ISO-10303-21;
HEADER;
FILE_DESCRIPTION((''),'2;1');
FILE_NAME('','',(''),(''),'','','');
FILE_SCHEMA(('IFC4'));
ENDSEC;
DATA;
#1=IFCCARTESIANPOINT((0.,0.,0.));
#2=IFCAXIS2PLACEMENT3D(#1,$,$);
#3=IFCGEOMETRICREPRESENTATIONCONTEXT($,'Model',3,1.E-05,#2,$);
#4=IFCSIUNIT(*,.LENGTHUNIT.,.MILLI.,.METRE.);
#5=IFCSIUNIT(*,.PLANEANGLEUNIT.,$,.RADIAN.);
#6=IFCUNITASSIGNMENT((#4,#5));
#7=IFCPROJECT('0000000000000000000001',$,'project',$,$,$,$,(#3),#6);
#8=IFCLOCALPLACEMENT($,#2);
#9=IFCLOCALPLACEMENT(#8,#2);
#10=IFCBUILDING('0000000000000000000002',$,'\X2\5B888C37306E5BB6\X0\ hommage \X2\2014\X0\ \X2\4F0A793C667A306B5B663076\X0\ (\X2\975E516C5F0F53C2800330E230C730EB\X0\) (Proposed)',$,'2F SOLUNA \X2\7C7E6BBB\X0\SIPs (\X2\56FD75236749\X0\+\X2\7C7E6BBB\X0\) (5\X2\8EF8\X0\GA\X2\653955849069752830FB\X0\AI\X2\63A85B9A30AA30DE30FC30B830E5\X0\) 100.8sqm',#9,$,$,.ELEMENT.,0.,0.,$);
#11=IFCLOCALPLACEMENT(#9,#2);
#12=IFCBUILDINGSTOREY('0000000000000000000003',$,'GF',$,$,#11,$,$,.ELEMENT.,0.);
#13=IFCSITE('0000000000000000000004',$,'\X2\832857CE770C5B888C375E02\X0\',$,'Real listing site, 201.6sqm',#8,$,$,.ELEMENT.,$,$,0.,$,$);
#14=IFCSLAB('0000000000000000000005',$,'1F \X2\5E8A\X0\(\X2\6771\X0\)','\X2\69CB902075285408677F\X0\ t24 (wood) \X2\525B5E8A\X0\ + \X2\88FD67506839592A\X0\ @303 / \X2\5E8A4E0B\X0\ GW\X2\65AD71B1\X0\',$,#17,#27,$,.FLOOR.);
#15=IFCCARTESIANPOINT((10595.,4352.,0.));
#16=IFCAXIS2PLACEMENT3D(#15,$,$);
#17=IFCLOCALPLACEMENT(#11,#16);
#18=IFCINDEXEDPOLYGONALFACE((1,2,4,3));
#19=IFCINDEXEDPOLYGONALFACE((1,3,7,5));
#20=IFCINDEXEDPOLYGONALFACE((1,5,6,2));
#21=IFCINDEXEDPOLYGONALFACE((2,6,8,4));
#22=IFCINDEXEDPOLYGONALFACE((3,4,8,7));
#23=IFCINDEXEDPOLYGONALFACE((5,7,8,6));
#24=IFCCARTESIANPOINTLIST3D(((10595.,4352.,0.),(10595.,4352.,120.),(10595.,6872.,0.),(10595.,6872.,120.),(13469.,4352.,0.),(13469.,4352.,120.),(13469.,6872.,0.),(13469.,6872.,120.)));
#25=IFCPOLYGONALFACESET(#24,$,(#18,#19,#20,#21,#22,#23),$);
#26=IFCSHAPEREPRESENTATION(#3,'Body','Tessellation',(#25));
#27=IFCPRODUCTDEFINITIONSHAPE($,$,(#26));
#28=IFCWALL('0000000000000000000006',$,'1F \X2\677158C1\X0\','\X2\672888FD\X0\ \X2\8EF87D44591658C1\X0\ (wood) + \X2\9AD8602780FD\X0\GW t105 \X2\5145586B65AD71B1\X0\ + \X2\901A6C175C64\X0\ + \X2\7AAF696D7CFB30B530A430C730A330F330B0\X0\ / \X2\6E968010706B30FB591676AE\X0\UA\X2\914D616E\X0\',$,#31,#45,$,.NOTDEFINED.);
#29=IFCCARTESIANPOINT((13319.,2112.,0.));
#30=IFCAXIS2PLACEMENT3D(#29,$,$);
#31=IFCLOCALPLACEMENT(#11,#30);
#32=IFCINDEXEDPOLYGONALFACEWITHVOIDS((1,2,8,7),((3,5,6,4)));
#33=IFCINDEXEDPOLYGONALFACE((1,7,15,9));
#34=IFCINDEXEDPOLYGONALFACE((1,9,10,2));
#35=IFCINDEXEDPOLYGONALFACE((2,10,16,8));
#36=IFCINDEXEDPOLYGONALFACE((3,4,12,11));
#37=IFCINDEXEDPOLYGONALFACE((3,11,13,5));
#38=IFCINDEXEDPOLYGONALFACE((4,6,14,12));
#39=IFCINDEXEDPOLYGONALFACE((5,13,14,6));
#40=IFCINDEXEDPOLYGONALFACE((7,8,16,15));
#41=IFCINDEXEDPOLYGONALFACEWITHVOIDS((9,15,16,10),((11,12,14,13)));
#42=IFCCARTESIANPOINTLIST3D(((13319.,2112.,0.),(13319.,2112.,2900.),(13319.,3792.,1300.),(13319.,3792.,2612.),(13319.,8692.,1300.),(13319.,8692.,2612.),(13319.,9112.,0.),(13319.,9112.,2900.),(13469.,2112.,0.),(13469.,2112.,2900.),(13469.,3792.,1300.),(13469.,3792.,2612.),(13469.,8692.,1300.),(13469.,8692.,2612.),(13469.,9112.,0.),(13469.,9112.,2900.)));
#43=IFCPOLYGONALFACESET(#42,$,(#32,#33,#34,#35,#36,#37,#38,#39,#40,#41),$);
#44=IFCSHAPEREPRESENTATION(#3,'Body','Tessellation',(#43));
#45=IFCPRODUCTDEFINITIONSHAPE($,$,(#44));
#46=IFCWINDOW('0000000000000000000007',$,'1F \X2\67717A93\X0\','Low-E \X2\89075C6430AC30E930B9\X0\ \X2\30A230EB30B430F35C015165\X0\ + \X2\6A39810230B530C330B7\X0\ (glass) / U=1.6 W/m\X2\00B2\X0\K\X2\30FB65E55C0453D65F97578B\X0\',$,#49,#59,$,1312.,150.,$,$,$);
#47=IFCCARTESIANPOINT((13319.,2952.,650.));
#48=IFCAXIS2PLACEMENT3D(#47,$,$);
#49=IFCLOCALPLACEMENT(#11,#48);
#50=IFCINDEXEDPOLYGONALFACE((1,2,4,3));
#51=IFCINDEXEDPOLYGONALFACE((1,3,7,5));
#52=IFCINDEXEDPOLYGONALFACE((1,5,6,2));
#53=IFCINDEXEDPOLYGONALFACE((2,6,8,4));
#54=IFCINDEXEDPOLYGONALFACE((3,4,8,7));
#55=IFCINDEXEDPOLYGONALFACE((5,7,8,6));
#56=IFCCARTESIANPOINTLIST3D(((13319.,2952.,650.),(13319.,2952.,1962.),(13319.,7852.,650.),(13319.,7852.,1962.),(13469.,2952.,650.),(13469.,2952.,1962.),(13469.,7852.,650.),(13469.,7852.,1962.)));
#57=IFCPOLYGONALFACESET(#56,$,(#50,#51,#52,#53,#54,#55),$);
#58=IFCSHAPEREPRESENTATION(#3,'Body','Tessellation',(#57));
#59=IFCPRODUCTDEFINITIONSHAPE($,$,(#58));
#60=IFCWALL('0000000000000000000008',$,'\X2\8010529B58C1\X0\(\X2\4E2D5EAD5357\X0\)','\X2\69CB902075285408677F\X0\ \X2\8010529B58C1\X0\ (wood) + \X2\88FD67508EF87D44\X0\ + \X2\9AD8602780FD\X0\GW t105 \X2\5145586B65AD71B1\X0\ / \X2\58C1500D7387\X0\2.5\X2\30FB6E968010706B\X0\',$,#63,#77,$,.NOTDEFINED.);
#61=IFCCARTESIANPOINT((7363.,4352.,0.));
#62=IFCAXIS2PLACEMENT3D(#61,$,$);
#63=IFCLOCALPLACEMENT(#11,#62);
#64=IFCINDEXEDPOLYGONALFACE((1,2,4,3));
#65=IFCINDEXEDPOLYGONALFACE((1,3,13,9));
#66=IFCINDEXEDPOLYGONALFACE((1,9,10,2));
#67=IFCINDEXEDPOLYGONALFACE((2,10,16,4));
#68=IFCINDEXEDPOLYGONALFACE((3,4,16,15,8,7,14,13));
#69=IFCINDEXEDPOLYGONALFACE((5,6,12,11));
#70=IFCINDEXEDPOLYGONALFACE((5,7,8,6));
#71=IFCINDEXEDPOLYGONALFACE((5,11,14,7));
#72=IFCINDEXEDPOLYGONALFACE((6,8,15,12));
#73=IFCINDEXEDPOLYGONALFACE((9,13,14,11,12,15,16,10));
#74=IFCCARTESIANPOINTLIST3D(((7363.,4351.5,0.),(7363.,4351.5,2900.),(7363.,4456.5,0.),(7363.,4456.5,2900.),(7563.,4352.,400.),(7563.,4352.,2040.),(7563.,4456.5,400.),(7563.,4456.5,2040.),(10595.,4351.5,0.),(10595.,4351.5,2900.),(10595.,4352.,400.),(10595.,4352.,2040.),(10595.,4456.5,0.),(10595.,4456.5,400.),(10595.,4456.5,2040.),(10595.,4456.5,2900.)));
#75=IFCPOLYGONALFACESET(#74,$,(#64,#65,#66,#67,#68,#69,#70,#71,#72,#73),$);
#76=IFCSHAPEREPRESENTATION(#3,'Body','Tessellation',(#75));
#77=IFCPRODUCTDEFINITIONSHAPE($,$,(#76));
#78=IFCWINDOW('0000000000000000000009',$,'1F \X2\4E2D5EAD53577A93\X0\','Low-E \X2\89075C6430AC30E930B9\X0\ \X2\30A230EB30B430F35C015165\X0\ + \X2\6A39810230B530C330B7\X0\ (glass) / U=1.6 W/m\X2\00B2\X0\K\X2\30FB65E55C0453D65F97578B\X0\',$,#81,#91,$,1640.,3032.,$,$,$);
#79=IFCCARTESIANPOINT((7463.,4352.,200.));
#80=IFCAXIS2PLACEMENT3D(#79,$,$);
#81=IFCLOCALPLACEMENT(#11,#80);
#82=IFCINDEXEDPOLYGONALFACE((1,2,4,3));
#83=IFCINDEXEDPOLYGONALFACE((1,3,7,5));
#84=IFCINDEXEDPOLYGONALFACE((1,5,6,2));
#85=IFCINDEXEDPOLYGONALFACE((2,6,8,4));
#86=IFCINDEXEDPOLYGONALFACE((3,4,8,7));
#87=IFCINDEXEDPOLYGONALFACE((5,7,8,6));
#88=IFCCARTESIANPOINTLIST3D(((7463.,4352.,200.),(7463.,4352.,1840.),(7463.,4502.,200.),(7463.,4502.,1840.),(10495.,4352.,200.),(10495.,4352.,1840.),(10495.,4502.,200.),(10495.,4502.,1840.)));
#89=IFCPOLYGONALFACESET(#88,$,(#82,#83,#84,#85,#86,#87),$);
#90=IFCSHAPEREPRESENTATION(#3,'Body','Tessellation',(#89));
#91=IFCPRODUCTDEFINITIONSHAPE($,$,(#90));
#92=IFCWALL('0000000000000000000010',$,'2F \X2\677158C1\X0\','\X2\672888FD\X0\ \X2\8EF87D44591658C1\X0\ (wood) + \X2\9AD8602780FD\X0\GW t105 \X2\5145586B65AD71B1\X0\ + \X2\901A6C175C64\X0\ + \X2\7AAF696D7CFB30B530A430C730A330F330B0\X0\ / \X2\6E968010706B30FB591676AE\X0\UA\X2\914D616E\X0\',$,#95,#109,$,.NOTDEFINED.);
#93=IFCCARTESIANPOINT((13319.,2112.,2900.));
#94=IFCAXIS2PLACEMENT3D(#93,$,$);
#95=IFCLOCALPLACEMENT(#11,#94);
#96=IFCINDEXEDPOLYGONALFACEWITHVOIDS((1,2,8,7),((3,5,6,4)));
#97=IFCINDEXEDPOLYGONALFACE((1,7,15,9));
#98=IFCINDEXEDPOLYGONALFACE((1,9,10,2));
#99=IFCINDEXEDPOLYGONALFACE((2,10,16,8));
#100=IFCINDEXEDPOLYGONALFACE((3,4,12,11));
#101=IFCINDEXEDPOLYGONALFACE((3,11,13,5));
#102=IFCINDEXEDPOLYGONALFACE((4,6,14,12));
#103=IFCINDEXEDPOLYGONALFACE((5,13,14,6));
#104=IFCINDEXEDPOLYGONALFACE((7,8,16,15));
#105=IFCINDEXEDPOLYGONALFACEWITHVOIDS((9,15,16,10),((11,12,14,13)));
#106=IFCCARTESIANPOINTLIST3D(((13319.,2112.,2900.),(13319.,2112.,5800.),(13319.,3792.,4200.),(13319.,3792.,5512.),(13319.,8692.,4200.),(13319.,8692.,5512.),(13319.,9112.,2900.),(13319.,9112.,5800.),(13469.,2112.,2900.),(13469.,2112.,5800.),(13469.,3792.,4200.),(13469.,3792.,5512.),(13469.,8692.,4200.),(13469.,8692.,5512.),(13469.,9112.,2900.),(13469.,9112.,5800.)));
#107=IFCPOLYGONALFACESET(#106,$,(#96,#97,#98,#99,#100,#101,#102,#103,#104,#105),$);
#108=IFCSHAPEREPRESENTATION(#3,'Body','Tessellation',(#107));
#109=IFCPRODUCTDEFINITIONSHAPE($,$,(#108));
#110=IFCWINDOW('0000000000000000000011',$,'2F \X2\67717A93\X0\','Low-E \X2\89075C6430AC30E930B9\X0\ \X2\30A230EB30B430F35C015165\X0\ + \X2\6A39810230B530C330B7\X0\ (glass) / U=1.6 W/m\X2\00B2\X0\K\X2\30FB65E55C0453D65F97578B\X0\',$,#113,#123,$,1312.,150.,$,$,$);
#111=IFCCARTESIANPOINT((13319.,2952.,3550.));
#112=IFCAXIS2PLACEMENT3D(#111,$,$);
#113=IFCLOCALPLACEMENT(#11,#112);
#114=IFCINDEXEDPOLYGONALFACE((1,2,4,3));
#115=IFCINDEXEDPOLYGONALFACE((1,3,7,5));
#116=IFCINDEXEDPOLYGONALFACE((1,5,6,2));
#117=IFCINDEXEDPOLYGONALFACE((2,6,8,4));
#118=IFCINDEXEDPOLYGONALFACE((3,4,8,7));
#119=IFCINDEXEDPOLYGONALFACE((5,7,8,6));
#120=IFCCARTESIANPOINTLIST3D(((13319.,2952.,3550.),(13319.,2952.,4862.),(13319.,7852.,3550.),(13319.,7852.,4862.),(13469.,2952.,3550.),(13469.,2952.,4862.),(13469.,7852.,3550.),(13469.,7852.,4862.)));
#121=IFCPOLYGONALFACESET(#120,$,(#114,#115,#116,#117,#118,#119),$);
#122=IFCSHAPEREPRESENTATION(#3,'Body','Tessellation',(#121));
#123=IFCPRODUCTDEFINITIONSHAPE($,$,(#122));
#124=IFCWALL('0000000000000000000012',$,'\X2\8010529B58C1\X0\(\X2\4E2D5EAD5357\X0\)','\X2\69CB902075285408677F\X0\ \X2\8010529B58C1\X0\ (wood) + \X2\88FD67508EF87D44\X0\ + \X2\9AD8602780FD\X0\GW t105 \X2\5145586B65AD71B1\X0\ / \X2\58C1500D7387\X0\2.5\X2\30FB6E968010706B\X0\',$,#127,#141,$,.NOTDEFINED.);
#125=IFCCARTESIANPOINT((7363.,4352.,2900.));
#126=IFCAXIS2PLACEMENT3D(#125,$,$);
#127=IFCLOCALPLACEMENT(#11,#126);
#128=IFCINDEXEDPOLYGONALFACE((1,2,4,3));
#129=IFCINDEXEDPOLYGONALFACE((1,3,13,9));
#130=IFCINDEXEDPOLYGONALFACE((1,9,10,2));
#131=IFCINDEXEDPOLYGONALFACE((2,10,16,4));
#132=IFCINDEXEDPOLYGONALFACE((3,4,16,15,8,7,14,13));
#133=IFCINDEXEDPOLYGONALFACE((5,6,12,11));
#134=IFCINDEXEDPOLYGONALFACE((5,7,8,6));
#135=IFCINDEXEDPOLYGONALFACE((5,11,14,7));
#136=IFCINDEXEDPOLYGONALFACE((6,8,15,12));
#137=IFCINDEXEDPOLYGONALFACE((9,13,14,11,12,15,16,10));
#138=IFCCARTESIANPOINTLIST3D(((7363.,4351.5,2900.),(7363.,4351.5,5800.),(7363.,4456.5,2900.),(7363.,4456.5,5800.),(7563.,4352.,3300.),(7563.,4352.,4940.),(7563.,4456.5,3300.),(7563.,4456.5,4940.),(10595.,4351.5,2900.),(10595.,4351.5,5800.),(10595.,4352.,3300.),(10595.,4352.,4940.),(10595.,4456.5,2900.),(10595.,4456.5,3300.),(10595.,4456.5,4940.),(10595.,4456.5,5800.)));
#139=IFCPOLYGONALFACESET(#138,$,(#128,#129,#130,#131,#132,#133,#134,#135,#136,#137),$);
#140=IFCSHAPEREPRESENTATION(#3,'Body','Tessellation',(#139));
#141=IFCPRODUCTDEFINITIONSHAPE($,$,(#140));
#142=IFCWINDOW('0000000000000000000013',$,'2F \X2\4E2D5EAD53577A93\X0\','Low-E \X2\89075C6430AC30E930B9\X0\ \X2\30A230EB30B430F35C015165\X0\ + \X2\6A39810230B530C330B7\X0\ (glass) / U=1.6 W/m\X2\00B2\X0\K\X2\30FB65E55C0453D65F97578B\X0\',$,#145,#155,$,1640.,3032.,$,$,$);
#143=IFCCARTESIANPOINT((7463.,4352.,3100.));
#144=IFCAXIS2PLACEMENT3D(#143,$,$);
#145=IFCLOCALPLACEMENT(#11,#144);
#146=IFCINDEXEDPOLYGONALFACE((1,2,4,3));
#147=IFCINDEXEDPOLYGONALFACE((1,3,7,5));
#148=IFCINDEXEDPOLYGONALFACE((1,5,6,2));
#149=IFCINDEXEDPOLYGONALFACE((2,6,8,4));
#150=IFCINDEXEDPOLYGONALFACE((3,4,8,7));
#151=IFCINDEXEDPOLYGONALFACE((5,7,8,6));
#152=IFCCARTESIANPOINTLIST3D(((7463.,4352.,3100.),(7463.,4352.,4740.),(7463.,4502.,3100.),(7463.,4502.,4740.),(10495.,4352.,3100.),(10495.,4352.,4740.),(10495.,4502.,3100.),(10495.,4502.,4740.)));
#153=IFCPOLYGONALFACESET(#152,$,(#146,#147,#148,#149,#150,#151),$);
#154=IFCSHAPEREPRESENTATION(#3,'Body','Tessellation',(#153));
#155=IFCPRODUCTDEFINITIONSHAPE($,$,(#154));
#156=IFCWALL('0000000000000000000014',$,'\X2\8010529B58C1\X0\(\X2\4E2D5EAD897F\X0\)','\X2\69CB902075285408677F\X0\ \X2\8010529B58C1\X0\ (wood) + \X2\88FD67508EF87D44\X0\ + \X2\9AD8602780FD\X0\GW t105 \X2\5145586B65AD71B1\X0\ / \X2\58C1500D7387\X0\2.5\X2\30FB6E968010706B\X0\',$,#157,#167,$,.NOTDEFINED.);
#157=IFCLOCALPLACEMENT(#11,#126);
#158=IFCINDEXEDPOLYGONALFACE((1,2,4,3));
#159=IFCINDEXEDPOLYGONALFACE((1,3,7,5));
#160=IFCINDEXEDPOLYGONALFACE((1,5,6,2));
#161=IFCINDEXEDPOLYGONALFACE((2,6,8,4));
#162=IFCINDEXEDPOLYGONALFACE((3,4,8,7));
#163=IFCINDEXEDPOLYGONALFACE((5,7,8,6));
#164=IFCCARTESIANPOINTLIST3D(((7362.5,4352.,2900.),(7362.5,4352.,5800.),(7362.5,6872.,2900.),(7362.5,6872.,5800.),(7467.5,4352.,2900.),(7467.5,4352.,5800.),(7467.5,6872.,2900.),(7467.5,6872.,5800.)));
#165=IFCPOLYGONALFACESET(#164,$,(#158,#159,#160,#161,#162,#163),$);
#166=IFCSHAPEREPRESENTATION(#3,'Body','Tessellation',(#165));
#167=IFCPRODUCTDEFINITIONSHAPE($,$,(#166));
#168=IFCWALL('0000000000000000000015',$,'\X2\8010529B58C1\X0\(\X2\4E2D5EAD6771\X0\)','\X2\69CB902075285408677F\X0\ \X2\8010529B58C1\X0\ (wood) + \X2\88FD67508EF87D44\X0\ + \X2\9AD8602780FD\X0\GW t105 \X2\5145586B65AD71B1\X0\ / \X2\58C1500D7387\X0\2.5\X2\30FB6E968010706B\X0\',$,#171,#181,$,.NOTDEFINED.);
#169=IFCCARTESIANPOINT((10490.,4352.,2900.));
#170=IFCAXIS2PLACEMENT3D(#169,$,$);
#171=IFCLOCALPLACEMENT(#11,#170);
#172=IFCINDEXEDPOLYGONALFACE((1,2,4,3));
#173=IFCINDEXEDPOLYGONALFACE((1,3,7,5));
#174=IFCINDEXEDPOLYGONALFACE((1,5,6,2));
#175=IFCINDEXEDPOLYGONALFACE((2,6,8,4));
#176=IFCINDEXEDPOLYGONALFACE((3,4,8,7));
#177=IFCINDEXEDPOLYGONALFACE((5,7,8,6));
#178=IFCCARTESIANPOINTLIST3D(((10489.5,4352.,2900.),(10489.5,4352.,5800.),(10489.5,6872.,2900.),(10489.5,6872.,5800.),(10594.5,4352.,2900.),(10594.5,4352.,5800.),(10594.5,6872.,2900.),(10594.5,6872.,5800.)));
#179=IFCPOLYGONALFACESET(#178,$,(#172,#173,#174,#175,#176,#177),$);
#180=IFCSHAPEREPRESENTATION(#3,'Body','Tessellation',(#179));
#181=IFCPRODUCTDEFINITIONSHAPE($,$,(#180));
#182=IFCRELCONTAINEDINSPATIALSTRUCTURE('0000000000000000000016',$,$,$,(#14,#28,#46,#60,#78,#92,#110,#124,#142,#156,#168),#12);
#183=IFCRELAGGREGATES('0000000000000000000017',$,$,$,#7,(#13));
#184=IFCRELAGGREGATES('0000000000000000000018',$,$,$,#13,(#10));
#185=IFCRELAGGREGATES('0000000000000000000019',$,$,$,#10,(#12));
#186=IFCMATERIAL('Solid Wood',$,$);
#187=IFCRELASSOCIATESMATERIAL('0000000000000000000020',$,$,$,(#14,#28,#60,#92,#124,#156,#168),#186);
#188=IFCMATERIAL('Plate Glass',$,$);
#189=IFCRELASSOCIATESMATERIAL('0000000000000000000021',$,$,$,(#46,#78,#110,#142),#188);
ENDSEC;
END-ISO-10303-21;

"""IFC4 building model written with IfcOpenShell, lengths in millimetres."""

from ifc_helpers import new_model, si_unit, frame, frame_2d, origin, place, context, project, spatial, rectangle, extrude, material, element, fill, save


model = new_model("IFC4")

# Units and contexts
model_context = context("Model", 3, precision=1e-05, world=origin())
ifc_project = project(units=[si_unit("LENGTHUNIT", "METRE", prefix="MILLI"), si_unit("PLANEANGLEUNIT", "RADIAN")], contexts=[model_context])

# Site, building, storey
site_placement = place(None, origin())
site = spatial("IfcSite", under=ifc_project, at=site_placement, Name="茨城県守谷市", ObjectType="Real listing site, 201.6sqm", CompositionType="ELEMENT", RefElevation=0.0)
building_placement = place(site_placement, origin())
building = spatial("IfcBuilding", under=site, at=building_placement, Name="守谷の家 hommage — 伊礼智に学ぶ (非公式参考モデル) (Proposed)", ObjectType="2F SOLUNA 籾殻SIPs (国産杉+籾殻) (5軸GA改善適用・AI推定オマージュ) 100.8sqm", CompositionType="ELEMENT", ElevationOfRefHeight=0.0, ElevationOfTerrain=0.0)
storey_placement = place(building_placement, origin())
storey = spatial("IfcBuildingStorey", under=building, at=storey_placement, Name="GF", CompositionType="ELEMENT", Elevation=0.0)

# Slab
ifc_material_1 = material(Name="Solid Wood")
slab_placement = place(storey_placement, frame((10595.0, 4352.0, 0.0)))
element("IfcSlab", 1, at=slab_placement, inside=storey, material=ifc_material_1, Name="1F 床(東)", Description="構造用合板 t24 (wood) 剛床 + 製材根太 @303 / 床下 GW断熱", PredefinedType="FLOOR", context=model_context, shape_type="SweptSolid", body=[
    extrude(rectangle(XDim=2874.0, YDim=2520.0, at=frame_2d((1437.0, 1260.0))), frame((10595.0, 4352.0, 0.0)), (0.0, 0.0, 1.0), 120.0),
])

# Walls, openings, windows
wall_1_placement = place(storey_placement, frame((13319.0, 2112.0, 0.0)))
wall_1 = element("IfcWall", 2, at=wall_1_placement, inside=storey, material=ifc_material_1, Name="1F 東壁", Description="木製 軸組外壁 (wood) + 高性能GW t105 充填断熱 + 通気層 + 窯業系サイディング / 準耐火・外皮UA配慮", PredefinedType="NOTDEFINED", context=model_context, shape_type="SweptSolid", body=[
    extrude(rectangle(XDim=150.0, YDim=7000.0, at=frame_2d((75.0, 3500.0))), frame((13319.0, 2112.0, 0.0)), (0.0, 0.0, 1.0), 2900.0),
])
opening_1_placement = place(storey_placement, frame((13319.0, 2952.0, 650.0)))
opening_1 = element("IfcOpeningElement", 3, at=opening_1_placement, cuts=wall_1, PredefinedType="NOTDEFINED", context=model_context, shape_type="SweptSolid", body=[
    extrude(rectangle(XDim=150.0, YDim=4900.0, at=frame_2d((75.0, 2450.0))), frame((13319.0, 2952.0, 650.0)), (0.0, 0.0, 1.0), 1312.0),
])
ifc_material_2 = material(Name="Plate Glass")
window_1_placement = place(storey_placement, frame((13319.0, 2952.0, 650.0)))
window_1 = element("IfcWindow", 4, at=window_1_placement, inside=storey, material=ifc_material_2, Name="1F 東窓", Description="Low-E 複層ガラス アルゴン封入 + 樹脂サッシ (glass) / U=1.6 W/m²K・日射取得型", OverallHeight=1312.0, OverallWidth=150.0, context=model_context, shape_type="SweptSolid", body=[
    extrude(rectangle(XDim=150.0, YDim=4900.0, at=frame_2d((75.0, 2450.0))), frame((13319.0, 2952.0, 650.0)), (0.0, 0.0, 1.0), 1312.0),
])
fill(opening_1, window_1)
wall_2_placement = place(storey_placement, frame((7363.0, 4352.0, 0.0)))
wall_2 = element("IfcWall", 5, at=wall_2_placement, inside=storey, material=ifc_material_1, Name="耐力壁(中庭南)", Description="構造用合板 耐力壁 (wood) + 製材軸組 + 高性能GW t105 充填断熱 / 壁倍率2.5・準耐火", PredefinedType="NOTDEFINED", context=model_context, shape_type="SweptSolid", body=[
    extrude(rectangle(XDim=3232.0, YDim=105.0, at=frame_2d((1616.0, 52.0))), frame((7363.0, 4352.0, 0.0)), (0.0, 0.0, 1.0), 2900.0),
])
opening_2_placement = place(storey_placement, frame((7463.0, 4352.0, 200.0)))
opening_2 = element("IfcOpeningElement", 6, at=opening_2_placement, cuts=wall_2, PredefinedType="NOTDEFINED", context=model_context, shape_type="SweptSolid", body=[
    extrude(rectangle(XDim=3032.0, YDim=150.0, at=frame_2d((1516.0, 75.0))), frame((7463.0, 4352.0, 200.0)), (0.0, 0.0, 1.0), 1640.0),
])
window_2_placement = place(storey_placement, frame((7463.0, 4352.0, 200.0)))
window_2 = element("IfcWindow", 7, at=window_2_placement, inside=storey, material=ifc_material_2, Name="1F 中庭南窓", Description="Low-E 複層ガラス アルゴン封入 + 樹脂サッシ (glass) / U=1.6 W/m²K・日射取得型", OverallHeight=1640.0, OverallWidth=3032.0, context=model_context, shape_type="SweptSolid", body=[
    extrude(rectangle(XDim=3032.0, YDim=150.0, at=frame_2d((1516.0, 75.0))), frame((7463.0, 4352.0, 200.0)), (0.0, 0.0, 1.0), 1640.0),
])
fill(opening_2, window_2)

# Walls, openings, windows
wall_3_placement = place(storey_placement, frame((13319.0, 2112.0, 2900.0)))
wall_3 = element("IfcWall", 8, at=wall_3_placement, inside=storey, material=ifc_material_1, Name="2F 東壁", Description="木製 軸組外壁 (wood) + 高性能GW t105 充填断熱 + 通気層 + 窯業系サイディング / 準耐火・外皮UA配慮", PredefinedType="NOTDEFINED", context=model_context, shape_type="SweptSolid", body=[
    extrude(rectangle(XDim=150.0, YDim=7000.0, at=frame_2d((75.0, 3500.0))), frame((13319.0, 2112.0, 2900.0)), (0.0, 0.0, 1.0), 2900.0),
])
opening_3_placement = place(storey_placement, frame((13319.0, 2952.0, 3550.0)))
opening_3 = element("IfcOpeningElement", 9, at=opening_3_placement, cuts=wall_3, PredefinedType="NOTDEFINED", context=model_context, shape_type="SweptSolid", body=[
    extrude(rectangle(XDim=150.0, YDim=4900.0, at=frame_2d((75.0, 2450.0))), frame((13319.0, 2952.0, 3550.0)), (0.0, 0.0, 1.0), 1312.0),
])
window_3_placement = place(storey_placement, frame((13319.0, 2952.0, 3550.0)))
window_3 = element("IfcWindow", 10, at=window_3_placement, inside=storey, material=ifc_material_2, Name="2F 東窓", Description="Low-E 複層ガラス アルゴン封入 + 樹脂サッシ (glass) / U=1.6 W/m²K・日射取得型", OverallHeight=1312.0, OverallWidth=150.0, context=model_context, shape_type="SweptSolid", body=[
    extrude(rectangle(XDim=150.0, YDim=4900.0, at=frame_2d((75.0, 2450.0))), frame((13319.0, 2952.0, 3550.0)), (0.0, 0.0, 1.0), 1312.0),
])
fill(opening_3, window_3)
wall_4_placement = place(storey_placement, frame((7363.0, 4352.0, 2900.0)))
wall_4 = element("IfcWall", 11, at=wall_4_placement, inside=storey, material=ifc_material_1, Name="耐力壁(中庭南)", Description="構造用合板 耐力壁 (wood) + 製材軸組 + 高性能GW t105 充填断熱 / 壁倍率2.5・準耐火", PredefinedType="NOTDEFINED", context=model_context, shape_type="SweptSolid", body=[
    extrude(rectangle(XDim=3232.0, YDim=105.0, at=frame_2d((1616.0, 52.0))), frame((7363.0, 4352.0, 2900.0)), (0.0, 0.0, 1.0), 2900.0),
])
opening_4_placement = place(storey_placement, frame((7463.0, 4352.0, 3100.0)))
opening_4 = element("IfcOpeningElement", 12, at=opening_4_placement, cuts=wall_4, PredefinedType="NOTDEFINED", context=model_context, shape_type="SweptSolid", body=[
    extrude(rectangle(XDim=3032.0, YDim=150.0, at=frame_2d((1516.0, 75.0))), frame((7463.0, 4352.0, 3100.0)), (0.0, 0.0, 1.0), 1640.0),
])
window_4_placement = place(storey_placement, frame((7463.0, 4352.0, 3100.0)))
window_4 = element("IfcWindow", 13, at=window_4_placement, inside=storey, material=ifc_material_2, Name="2F 中庭南窓", Description="Low-E 複層ガラス アルゴン封入 + 樹脂サッシ (glass) / U=1.6 W/m²K・日射取得型", OverallHeight=1640.0, OverallWidth=3032.0, context=model_context, shape_type="SweptSolid", body=[
    extrude(rectangle(XDim=3032.0, YDim=150.0, at=frame_2d((1516.0, 75.0))), frame((7463.0, 4352.0, 3100.0)), (0.0, 0.0, 1.0), 1640.0),
])
fill(opening_4, window_4)

# Walls
wall_5_placement = place(storey_placement, frame((7363.0, 4352.0, 2900.0)))
element("IfcWall", 14, at=wall_5_placement, inside=storey, material=ifc_material_1, Name="耐力壁(中庭西)", Description="構造用合板 耐力壁 (wood) + 製材軸組 + 高性能GW t105 充填断熱 / 壁倍率2.5・準耐火", PredefinedType="NOTDEFINED", context=model_context, shape_type="SweptSolid", body=[
    extrude(rectangle(XDim=105.0, YDim=2520.0, at=frame_2d((52.0, 1260.0))), frame((7363.0, 4352.0, 2900.0)), (0.0, 0.0, 1.0), 2900.0),
])
wall_6_placement = place(storey_placement, frame((10490.0, 4352.0, 2900.0)))
element("IfcWall", 15, at=wall_6_placement, inside=storey, material=ifc_material_1, Name="耐力壁(中庭東)", Description="構造用合板 耐力壁 (wood) + 製材軸組 + 高性能GW t105 充填断熱 / 壁倍率2.5・準耐火", PredefinedType="NOTDEFINED", context=model_context, shape_type="SweptSolid", body=[
    extrude(rectangle(XDim=105.0, YDim=2520.0, at=frame_2d((52.0, 1260.0))), frame((10490.0, 4352.0, 2900.0)), (0.0, 0.0, 1.0), 2900.0),
])

save(model, "model.ifc")
